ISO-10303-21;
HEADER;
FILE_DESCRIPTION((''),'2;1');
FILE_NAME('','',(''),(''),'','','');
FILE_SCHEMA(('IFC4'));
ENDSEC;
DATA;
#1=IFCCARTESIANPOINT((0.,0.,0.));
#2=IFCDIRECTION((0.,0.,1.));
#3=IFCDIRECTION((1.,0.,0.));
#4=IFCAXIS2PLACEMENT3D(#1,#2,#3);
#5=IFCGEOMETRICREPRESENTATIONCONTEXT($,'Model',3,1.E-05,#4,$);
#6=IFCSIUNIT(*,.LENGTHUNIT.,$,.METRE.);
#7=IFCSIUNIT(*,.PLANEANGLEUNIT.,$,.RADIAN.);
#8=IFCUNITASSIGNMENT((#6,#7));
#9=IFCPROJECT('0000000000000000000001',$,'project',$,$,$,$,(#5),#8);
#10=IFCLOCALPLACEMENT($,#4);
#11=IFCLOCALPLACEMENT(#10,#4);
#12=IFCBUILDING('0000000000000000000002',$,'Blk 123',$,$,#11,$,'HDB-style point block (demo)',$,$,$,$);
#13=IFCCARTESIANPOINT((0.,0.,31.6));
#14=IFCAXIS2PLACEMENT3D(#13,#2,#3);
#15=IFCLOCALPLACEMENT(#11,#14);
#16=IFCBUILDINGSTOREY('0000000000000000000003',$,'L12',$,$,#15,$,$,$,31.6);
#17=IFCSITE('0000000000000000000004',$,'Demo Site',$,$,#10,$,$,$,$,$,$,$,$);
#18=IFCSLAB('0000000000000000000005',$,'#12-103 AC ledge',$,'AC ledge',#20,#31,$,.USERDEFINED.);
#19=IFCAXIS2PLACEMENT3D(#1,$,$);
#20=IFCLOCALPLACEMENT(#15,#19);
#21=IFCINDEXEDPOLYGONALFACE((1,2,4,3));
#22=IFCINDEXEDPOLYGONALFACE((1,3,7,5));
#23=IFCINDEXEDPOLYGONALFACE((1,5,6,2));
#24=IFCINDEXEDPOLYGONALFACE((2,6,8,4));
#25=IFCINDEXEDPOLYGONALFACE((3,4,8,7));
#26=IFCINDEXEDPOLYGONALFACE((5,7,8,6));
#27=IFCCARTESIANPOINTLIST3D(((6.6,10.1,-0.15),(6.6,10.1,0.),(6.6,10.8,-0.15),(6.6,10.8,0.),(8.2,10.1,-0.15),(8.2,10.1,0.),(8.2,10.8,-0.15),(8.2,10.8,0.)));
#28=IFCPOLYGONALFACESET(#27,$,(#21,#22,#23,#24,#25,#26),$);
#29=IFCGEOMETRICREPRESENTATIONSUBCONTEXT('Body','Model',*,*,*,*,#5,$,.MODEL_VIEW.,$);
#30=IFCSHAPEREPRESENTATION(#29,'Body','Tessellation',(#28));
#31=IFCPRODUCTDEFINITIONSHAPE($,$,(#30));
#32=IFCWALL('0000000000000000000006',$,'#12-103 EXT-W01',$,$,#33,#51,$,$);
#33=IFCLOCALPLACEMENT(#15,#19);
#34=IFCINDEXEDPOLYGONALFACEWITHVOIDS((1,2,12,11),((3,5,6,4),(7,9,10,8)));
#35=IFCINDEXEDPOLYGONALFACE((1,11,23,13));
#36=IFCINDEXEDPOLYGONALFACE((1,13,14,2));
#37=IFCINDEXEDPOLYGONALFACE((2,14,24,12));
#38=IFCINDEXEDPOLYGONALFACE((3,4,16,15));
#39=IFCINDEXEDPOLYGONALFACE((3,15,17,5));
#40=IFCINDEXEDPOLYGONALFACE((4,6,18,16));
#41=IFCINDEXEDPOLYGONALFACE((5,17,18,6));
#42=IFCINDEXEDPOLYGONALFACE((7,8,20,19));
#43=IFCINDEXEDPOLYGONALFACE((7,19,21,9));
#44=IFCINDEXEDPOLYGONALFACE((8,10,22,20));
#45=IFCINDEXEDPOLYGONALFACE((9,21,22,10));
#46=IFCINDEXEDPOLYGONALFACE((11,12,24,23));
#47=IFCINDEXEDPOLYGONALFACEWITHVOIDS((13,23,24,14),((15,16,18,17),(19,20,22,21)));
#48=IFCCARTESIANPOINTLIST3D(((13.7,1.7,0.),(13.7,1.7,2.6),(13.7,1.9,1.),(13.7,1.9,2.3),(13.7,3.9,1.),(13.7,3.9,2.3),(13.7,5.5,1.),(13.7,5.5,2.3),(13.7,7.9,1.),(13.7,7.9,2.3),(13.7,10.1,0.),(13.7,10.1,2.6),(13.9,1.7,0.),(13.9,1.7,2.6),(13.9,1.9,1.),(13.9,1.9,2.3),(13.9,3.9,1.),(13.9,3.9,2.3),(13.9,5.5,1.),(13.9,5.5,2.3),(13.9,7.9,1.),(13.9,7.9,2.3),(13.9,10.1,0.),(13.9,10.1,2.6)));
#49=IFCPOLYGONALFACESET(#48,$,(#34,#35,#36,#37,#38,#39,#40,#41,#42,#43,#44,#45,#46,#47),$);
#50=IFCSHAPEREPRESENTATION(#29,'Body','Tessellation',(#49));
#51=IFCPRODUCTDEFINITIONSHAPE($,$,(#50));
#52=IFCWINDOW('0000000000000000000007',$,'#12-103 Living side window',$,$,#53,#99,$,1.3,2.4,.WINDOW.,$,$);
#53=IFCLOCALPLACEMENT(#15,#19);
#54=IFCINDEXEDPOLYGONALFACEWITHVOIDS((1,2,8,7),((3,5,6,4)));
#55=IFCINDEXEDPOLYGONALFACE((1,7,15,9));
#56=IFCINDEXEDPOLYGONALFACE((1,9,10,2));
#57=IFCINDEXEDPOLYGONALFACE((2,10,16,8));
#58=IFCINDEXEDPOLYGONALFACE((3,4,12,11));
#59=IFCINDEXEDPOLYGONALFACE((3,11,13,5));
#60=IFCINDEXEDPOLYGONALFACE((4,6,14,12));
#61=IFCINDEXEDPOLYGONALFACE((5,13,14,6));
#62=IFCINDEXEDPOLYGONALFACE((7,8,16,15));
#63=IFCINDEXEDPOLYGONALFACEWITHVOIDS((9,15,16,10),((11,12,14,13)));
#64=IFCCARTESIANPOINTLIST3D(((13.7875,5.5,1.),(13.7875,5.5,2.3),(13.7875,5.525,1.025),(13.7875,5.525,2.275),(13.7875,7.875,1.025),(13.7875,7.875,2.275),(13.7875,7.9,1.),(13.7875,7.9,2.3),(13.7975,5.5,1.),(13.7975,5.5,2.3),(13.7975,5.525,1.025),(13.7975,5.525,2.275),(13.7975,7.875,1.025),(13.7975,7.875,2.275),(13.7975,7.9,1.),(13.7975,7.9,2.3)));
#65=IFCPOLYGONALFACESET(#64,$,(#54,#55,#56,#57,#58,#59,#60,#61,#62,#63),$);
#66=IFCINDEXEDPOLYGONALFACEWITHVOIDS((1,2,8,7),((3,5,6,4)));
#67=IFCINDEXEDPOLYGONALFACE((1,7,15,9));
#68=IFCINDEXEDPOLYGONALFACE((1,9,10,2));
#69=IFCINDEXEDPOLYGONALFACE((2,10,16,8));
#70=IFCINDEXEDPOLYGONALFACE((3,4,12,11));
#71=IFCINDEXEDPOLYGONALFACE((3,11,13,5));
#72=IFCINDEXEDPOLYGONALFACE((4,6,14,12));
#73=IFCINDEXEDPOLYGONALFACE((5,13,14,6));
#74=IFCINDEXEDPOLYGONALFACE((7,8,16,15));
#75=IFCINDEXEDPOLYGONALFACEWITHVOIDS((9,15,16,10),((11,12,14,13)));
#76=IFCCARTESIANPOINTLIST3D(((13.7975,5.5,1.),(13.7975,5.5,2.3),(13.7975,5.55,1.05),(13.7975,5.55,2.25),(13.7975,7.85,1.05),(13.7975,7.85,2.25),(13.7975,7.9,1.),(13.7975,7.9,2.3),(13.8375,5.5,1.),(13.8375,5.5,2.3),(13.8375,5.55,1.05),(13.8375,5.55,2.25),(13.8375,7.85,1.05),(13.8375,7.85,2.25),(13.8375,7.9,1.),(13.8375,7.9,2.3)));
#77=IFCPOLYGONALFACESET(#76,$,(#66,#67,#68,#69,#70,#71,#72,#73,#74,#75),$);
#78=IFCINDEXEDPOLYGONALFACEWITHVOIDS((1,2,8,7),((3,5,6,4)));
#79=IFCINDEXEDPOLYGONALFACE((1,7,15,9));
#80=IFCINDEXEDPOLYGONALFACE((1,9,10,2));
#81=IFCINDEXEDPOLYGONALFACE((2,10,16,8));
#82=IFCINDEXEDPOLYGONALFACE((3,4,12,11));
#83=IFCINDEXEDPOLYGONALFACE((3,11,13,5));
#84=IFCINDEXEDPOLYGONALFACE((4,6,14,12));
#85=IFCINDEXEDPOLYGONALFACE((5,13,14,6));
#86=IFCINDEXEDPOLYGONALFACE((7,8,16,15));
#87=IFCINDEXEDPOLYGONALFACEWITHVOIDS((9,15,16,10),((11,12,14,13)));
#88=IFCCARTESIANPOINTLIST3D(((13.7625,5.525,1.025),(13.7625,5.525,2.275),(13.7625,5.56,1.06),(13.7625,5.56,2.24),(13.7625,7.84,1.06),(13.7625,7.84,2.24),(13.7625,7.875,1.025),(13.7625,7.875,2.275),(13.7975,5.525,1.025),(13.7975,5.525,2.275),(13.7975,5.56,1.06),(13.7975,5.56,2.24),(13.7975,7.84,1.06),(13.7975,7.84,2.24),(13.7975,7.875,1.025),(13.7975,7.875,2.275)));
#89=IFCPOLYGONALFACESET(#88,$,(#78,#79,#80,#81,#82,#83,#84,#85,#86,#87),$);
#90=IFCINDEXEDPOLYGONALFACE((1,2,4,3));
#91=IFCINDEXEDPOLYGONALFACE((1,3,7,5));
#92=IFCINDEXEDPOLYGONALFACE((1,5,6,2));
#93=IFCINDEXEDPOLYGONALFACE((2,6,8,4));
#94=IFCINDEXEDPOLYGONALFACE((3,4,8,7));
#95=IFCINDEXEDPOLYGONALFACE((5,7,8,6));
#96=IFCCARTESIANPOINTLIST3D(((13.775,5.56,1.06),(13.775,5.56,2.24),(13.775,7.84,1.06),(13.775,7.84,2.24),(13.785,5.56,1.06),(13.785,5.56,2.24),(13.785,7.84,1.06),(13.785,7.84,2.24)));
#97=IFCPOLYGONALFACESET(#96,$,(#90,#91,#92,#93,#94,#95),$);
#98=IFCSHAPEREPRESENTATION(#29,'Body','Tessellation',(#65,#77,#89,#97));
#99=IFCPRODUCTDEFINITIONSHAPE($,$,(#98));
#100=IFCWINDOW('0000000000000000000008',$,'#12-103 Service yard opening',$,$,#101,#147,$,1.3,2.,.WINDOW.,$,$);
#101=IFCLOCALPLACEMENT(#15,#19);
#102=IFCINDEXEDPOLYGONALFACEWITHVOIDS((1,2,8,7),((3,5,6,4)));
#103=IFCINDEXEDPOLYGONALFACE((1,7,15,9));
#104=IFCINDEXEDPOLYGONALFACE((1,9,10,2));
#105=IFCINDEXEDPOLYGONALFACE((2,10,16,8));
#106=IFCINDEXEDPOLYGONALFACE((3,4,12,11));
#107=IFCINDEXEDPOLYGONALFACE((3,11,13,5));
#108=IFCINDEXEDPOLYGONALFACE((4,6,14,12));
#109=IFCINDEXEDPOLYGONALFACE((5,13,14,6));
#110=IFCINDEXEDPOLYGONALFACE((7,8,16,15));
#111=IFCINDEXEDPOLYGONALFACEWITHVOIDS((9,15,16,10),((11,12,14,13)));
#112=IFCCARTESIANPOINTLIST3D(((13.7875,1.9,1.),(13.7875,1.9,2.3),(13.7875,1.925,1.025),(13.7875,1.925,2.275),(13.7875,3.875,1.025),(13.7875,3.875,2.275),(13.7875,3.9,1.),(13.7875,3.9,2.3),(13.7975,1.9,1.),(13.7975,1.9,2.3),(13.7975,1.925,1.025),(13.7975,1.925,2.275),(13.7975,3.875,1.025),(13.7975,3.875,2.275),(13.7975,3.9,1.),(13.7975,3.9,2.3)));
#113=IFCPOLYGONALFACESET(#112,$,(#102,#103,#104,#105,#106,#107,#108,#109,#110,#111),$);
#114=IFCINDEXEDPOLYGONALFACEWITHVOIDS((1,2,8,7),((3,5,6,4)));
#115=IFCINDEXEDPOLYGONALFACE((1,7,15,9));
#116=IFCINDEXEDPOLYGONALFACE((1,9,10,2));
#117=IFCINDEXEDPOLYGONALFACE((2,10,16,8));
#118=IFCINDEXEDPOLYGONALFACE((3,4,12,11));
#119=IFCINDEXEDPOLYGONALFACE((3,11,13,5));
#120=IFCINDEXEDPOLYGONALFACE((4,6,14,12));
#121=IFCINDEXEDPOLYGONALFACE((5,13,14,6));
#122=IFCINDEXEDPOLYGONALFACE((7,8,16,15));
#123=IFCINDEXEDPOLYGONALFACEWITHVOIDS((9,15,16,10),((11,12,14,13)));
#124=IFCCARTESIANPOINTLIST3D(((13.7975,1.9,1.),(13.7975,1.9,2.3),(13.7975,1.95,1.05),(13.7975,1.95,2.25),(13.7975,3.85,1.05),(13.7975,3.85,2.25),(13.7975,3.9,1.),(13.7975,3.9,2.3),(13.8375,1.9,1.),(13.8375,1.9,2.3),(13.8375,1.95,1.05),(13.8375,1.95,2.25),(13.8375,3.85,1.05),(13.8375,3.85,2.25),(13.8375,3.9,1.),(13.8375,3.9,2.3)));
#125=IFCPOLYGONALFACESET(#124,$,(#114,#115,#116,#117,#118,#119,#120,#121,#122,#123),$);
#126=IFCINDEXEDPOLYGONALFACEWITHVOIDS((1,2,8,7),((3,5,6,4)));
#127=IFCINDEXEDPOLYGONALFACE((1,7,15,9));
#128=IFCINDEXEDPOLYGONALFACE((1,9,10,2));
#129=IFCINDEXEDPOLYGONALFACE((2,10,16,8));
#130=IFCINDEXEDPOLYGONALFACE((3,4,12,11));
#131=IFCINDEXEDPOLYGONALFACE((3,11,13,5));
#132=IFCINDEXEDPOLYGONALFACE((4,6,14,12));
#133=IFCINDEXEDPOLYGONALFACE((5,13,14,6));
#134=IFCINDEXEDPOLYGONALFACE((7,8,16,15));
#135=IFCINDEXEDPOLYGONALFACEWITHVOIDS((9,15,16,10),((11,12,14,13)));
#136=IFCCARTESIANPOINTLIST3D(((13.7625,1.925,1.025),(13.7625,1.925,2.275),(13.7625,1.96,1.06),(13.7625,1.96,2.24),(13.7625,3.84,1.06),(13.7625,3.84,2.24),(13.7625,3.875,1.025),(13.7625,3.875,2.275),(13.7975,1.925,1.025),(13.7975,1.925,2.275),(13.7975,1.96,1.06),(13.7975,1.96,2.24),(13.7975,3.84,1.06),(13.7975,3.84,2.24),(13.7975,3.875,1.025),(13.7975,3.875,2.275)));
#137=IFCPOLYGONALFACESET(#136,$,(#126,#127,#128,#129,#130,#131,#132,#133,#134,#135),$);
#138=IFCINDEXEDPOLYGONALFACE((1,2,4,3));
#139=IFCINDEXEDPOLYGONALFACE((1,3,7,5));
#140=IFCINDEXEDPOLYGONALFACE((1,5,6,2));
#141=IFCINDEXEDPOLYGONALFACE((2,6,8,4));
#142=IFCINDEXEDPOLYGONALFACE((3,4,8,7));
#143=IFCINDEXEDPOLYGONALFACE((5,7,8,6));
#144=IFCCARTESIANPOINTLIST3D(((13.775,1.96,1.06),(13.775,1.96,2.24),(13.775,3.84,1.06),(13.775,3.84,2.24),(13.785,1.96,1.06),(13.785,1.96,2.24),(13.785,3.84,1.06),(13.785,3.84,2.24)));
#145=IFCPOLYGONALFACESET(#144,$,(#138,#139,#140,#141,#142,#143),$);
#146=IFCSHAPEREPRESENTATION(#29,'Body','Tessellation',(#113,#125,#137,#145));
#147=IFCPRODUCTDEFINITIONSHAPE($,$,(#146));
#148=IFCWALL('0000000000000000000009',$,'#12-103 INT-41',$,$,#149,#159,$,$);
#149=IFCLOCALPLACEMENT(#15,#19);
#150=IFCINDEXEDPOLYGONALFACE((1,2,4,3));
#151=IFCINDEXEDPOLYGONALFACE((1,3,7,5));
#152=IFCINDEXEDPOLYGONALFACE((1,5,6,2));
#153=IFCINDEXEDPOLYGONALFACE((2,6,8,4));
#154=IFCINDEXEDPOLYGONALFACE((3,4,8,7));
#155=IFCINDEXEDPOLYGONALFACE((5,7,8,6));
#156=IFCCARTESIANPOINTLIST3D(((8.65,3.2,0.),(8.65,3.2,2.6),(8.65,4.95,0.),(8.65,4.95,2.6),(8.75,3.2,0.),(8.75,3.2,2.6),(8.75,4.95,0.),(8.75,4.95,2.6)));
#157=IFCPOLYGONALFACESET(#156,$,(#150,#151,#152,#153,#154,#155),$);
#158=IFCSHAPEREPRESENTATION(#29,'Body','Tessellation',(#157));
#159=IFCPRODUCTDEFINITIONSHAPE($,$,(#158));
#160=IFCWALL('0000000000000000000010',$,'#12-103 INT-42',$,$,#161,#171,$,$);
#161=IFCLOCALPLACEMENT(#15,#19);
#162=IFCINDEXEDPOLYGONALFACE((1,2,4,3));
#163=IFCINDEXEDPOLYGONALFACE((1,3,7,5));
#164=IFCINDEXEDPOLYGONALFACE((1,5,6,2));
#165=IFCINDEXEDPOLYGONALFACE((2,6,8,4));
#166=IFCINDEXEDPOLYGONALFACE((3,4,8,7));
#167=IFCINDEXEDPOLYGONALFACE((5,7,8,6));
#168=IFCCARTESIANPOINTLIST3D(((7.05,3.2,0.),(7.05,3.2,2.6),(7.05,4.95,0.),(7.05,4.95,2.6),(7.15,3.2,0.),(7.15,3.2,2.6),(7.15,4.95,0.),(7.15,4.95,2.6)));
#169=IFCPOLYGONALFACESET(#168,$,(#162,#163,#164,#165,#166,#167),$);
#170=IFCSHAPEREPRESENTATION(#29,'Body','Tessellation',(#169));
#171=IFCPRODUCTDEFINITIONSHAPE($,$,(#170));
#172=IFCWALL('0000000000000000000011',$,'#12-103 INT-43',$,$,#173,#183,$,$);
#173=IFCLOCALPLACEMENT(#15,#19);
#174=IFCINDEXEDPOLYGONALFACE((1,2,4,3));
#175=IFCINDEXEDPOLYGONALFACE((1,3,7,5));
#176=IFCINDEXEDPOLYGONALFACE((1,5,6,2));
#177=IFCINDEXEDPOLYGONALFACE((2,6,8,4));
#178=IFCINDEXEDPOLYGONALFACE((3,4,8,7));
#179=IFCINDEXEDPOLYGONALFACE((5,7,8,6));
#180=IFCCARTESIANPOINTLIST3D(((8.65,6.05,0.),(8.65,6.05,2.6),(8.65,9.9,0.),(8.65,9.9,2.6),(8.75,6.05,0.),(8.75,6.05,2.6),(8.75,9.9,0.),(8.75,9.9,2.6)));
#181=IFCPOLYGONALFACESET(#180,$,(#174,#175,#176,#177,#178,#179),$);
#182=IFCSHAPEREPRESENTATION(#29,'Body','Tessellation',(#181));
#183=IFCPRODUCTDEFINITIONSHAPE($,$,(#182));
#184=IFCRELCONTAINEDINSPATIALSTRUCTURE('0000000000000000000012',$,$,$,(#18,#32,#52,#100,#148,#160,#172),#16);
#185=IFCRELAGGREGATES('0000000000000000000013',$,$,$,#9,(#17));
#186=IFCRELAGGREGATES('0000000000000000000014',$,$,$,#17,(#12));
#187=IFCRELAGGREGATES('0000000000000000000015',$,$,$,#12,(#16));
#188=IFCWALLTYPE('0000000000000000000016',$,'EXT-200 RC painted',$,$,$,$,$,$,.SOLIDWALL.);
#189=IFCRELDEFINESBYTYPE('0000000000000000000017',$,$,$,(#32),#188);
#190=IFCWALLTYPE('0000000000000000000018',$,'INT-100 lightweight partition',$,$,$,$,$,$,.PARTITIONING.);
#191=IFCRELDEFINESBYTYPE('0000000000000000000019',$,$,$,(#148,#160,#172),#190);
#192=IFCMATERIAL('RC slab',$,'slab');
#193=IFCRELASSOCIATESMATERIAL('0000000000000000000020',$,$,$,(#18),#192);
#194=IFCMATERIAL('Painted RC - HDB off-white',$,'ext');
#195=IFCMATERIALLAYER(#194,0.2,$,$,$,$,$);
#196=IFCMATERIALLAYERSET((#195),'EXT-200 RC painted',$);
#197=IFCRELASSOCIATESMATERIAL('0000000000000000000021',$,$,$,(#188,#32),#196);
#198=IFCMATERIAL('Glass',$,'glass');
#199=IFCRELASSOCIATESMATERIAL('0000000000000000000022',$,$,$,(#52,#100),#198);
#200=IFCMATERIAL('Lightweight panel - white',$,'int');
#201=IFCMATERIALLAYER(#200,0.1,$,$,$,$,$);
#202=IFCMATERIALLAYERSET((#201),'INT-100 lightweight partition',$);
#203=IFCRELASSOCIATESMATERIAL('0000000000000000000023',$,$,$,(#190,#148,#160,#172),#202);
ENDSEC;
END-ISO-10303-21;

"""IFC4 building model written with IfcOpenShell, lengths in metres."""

from ifc_helpers import new_model, si_unit, frame, origin, origin_with_axes, place, context, subcontext, project, spatial, polyline, line, indexed_curve, outline, extrude, material, layer, layer_set, layer_usage, type_object, element, fill, save


model = new_model("IFC4")

# Units and contexts
model_context = context("Model", 3, precision=1e-05, world=origin_with_axes())
body_context = subcontext(model_context, "Body", "Model", "MODEL_VIEW")
ifc_project = project(units=[si_unit("LENGTHUNIT", "METRE"), si_unit("PLANEANGLEUNIT", "RADIAN")], contexts=[model_context])

# Site, building, storey
site_placement = place(None, origin_with_axes())
site = spatial("IfcSite", under=ifc_project, at=site_placement, Name="Demo Site")
building_placement = place(site_placement, origin_with_axes())
building = spatial("IfcBuilding", under=site, at=building_placement, Name="Blk 123", LongName="HDB-style point block (demo)")
storey_placement = place(building_placement, frame((0.0, 0.0, 31.6), z_axis=(0.0, 0.0, 1.0), x_axis=(1.0, 0.0, 0.0)))
storey = spatial("IfcBuildingStorey", under=building, at=storey_placement, Name="L12", Elevation=31.6)

# Slab
ifc_material_1 = material(Name="RC slab", Category="slab")
slab_placement = place(storey_placement, frame((7.4, 10.45, -0.15), z_axis=(0.0, 0.0, 1.0), x_axis=(1.0, 0.0, 0.0)))
element("IfcSlab", 1, at=slab_placement, inside=storey, material=ifc_material_1, Name="#12-103 AC ledge", ObjectType="AC ledge", PredefinedType="USERDEFINED", context=body_context, shape_type="SweptSolid", body=[
    extrude(outline(polyline([(0.8, -0.35), (0.8, 0.35), (-0.8, 0.35), (-0.8, -0.35), (0.8, -0.35)])), origin(), (0.0, 0.0, 1.0), 0.15),
])

# Wall, openings, windows
ifc_material_2 = material(Name="Painted RC - HDB off-white", Category="ext")
ifc_layer_1 = layer(ifc_material_2, 0.2)
ifc_layer_set_1 = layer_set([ifc_layer_1], Name="EXT-200 RC painted")
ifc_layer_usage_1 = layer_usage(ifc_layer_set_1, "AXIS2", "POSITIVE", 0.0)
wall_type_1 = type_object("IfcWallType", Name="EXT-200 RC painted", PredefinedType="SOLIDWALL", material=ifc_layer_set_1)
wall_1_placement = place(storey_placement, frame((13.9, 1.7, 0.0), z_axis=(0.0, 0.0, 1.0), x_axis=(0.0, 1.0, 0.0)))
wall_1 = element("IfcWall", 2, at=wall_1_placement, inside=storey, type_object=wall_type_1, material=ifc_layer_usage_1, Name="#12-103 EXT-W01", context=body_context, shape_type="SweptSolid", body=[
    extrude(outline(indexed_curve([(0.0, 0.0), (0.0, 0.2), (8.4, 0.2), (8.4, 0.0), (0.0, 0.0)], self_intersect=False)), origin_with_axes(), (0.0, 0.0, 1.0), 2.6),
])
opening_1_placement = place(wall_1_placement, frame((3.8, -0.1, 1.0), z_axis=(0.0, 0.0, 1.0), x_axis=(1.0, 0.0, 0.0)))
opening_1 = element("IfcOpeningElement", 3, at=opening_1_placement, cuts=wall_1, context=body_context, shape_type="SweptSolid", body=[
    extrude(outline(indexed_curve([(0.0, 0.0), (0.0, 0.4), (2.4, 0.4), (2.4, 0.0), (0.0, 0.0)], self_intersect=False)), origin_with_axes(), (0.0, 0.0, 1.0), 1.3),
])
opening_2_placement = place(wall_1_placement, frame((0.2, -0.1, 1.0), z_axis=(0.0, 0.0, 1.0), x_axis=(1.0, 0.0, 0.0)))
opening_2 = element("IfcOpeningElement", 4, at=opening_2_placement, cuts=wall_1, context=body_context, shape_type="SweptSolid", body=[
    extrude(outline(indexed_curve([(0.0, 0.0), (0.0, 0.4), (2.0, 0.4), (2.0, 0.0), (0.0, 0.0)], self_intersect=False)), origin_with_axes(), (0.0, 0.0, 1.0), 1.3),
])
ifc_material_3 = material(Name="Glass", Category="glass")
window_1_placement = place(opening_1_placement, frame((0.0, 0.1125, 0.0), z_axis=(0.0, 0.0, 1.0), x_axis=(1.0, 0.0, 0.0)))
window_1 = element("IfcWindow", 5, at=window_1_placement, inside=storey, material=ifc_material_3, Name="#12-103 Living side window", OverallHeight=1.3, OverallWidth=2.4, PredefinedType="WINDOW", context=body_context, shape_type="SweptSolid", body=[
    extrude(outline(indexed_curve([(0.0, 0.0), (2.4, 0.0), (2.4, 1.3), (0.0, 1.3)], segments=[line(1, 2, 3, 4, 1)]), holes=[indexed_curve([(0.025, 0.025), (2.375, 0.025), (2.375, 1.275), (0.025, 1.275)], segments=[line(1, 2, 3, 4, 1)])]), frame((0.0, 0.09, 0.0), z_axis=(0.0, -1.0, 0.0), x_axis=(1.0, 0.0, 0.0)), (0.0, 0.0, -1.0), 0.01),
    extrude(outline(indexed_curve([(0.0, 0.0), (2.4, 0.0), (2.4, 1.3), (0.0, 1.3)], segments=[line(1, 2, 3, 4, 1)]), holes=[indexed_curve([(0.05, 0.05), (2.35, 0.05), (2.35, 1.25), (0.05, 1.25)], segments=[line(1, 2, 3, 4, 1)])]), frame((0.0, 0.05, 0.0), z_axis=(0.0, -1.0, 0.0), x_axis=(1.0, 0.0, 0.0)), (0.0, 0.0, -1.0), 0.04),
    extrude(outline(indexed_curve([(0.0, 0.0), (2.35, 0.0), (2.35, 1.25), (0.0, 1.25)], segments=[line(1, 2, 3, 4, 1)]), holes=[indexed_curve([(0.035, 0.035), (2.315, 0.035), (2.315, 1.215), (0.035, 1.215)], segments=[line(1, 2, 3, 4, 1)])]), frame((0.025, 0.09, 0.025), z_axis=(0.0, -1.0, 0.0), x_axis=(1.0, 0.0, 0.0)), (0.0, 0.0, -1.0), 0.035),
    extrude(outline(indexed_curve([(0.035, 0.035), (2.315, 0.035), (2.315, 1.215), (0.035, 1.215)], segments=[line(1, 2, 3, 4, 1)])), frame((0.025, 0.1025, 0.025), z_axis=(0.0, -1.0, 0.0), x_axis=(1.0, 0.0, 0.0)), (0.0, 0.0, -1.0), 0.01),
])
fill(opening_1, window_1)
window_2_placement = place(opening_2_placement, frame((0.0, 0.1125, 0.0), z_axis=(0.0, 0.0, 1.0), x_axis=(1.0, 0.0, 0.0)))
window_2 = element("IfcWindow", 6, at=window_2_placement, inside=storey, material=ifc_material_3, Name="#12-103 Service yard opening", OverallHeight=1.3, OverallWidth=2.0, PredefinedType="WINDOW", context=body_context, shape_type="SweptSolid", body=[
    extrude(outline(indexed_curve([(0.0, 0.0), (2.0, 0.0), (2.0, 1.3), (0.0, 1.3)], segments=[line(1, 2, 3, 4, 1)]), holes=[indexed_curve([(0.025, 0.025), (1.975, 0.025), (1.975, 1.275), (0.025, 1.275)], segments=[line(1, 2, 3, 4, 1)])]), frame((0.0, 0.09, 0.0), z_axis=(0.0, -1.0, 0.0), x_axis=(1.0, 0.0, 0.0)), (0.0, 0.0, -1.0), 0.01),
    extrude(outline(indexed_curve([(0.0, 0.0), (2.0, 0.0), (2.0, 1.3), (0.0, 1.3)], segments=[line(1, 2, 3, 4, 1)]), holes=[indexed_curve([(0.05, 0.05), (1.95, 0.05), (1.95, 1.25), (0.05, 1.25)], segments=[line(1, 2, 3, 4, 1)])]), frame((0.0, 0.05, 0.0), z_axis=(0.0, -1.0, 0.0), x_axis=(1.0, 0.0, 0.0)), (0.0, 0.0, -1.0), 0.04),
    extrude(outline(indexed_curve([(0.0, 0.0), (1.95, 0.0), (1.95, 1.25), (0.0, 1.25)], segments=[line(1, 2, 3, 4, 1)]), holes=[indexed_curve([(0.035, 0.035), (1.915, 0.035), (1.915, 1.215), (0.035, 1.215)], segments=[line(1, 2, 3, 4, 1)])]), frame((0.025, 0.09, 0.025), z_axis=(0.0, -1.0, 0.0), x_axis=(1.0, 0.0, 0.0)), (0.0, 0.0, -1.0), 0.035),
    extrude(outline(indexed_curve([(0.035, 0.035), (1.915, 0.035), (1.915, 1.215), (0.035, 1.215)], segments=[line(1, 2, 3, 4, 1)])), frame((0.025, 0.1025, 0.025), z_axis=(0.0, -1.0, 0.0), x_axis=(1.0, 0.0, 0.0)), (0.0, 0.0, -1.0), 0.01),
])
fill(opening_2, window_2)

# Walls
ifc_material_4 = material(Name="Lightweight panel - white", Category="int")
ifc_layer_2 = layer(ifc_material_4, 0.1)
ifc_layer_set_2 = layer_set([ifc_layer_2], Name="INT-100 lightweight partition")
ifc_layer_usage_2 = layer_usage(ifc_layer_set_2, "AXIS2", "POSITIVE", -0.05)
wall_type_2 = type_object("IfcWallType", Name="INT-100 lightweight partition", PredefinedType="PARTITIONING", material=ifc_layer_set_2)
for number, where, z_axis, x_axis, name in (
    (7, (8.7, 3.2, 0.0), (0.0, 0.0, 1.0), (0.0, 1.0, 0.0), "#12-103 INT-41"),
    (8, (7.1, 3.2, 0.0), (0.0, 0.0, 1.0), (0.0, 1.0, 0.0), "#12-103 INT-42"),
):
    element("IfcWall", number, at=place(storey_placement, frame(where, z_axis=z_axis, x_axis=x_axis)), inside=storey, type_object=wall_type_2, material=ifc_layer_usage_2, Name=name, context=body_context, shape_type="SweptSolid", body=[
        extrude(outline(indexed_curve([(0.0, 0.0), (0.0, 0.1), (1.75, 0.1), (1.75, 0.0), (0.0, 0.0)], self_intersect=False)), frame((0.0, -0.05, 0.0), z_axis=(0.0, 0.0, 1.0), x_axis=(1.0, 0.0, 0.0)), (0.0, 0.0, 1.0), 2.6),
    ])
wall_2_placement = place(storey_placement, frame((8.7, 6.05, 0.0), z_axis=(0.0, 0.0, 1.0), x_axis=(0.0, 1.0, 0.0)))
element("IfcWall", 9, at=wall_2_placement, inside=storey, type_object=wall_type_2, material=ifc_layer_usage_2, Name="#12-103 INT-43", context=body_context, shape_type="SweptSolid", body=[
    extrude(outline(indexed_curve([(0.0, 0.0), (0.0, 0.1), (3.85, 0.1), (3.85, 0.0), (0.0, 0.0)], self_intersect=False)), frame((0.0, -0.05, 0.0), z_axis=(0.0, 0.0, 1.0), x_axis=(1.0, 0.0, 0.0)), (0.0, 0.0, 1.0), 2.6),
])

save(model, "model.ifc")
